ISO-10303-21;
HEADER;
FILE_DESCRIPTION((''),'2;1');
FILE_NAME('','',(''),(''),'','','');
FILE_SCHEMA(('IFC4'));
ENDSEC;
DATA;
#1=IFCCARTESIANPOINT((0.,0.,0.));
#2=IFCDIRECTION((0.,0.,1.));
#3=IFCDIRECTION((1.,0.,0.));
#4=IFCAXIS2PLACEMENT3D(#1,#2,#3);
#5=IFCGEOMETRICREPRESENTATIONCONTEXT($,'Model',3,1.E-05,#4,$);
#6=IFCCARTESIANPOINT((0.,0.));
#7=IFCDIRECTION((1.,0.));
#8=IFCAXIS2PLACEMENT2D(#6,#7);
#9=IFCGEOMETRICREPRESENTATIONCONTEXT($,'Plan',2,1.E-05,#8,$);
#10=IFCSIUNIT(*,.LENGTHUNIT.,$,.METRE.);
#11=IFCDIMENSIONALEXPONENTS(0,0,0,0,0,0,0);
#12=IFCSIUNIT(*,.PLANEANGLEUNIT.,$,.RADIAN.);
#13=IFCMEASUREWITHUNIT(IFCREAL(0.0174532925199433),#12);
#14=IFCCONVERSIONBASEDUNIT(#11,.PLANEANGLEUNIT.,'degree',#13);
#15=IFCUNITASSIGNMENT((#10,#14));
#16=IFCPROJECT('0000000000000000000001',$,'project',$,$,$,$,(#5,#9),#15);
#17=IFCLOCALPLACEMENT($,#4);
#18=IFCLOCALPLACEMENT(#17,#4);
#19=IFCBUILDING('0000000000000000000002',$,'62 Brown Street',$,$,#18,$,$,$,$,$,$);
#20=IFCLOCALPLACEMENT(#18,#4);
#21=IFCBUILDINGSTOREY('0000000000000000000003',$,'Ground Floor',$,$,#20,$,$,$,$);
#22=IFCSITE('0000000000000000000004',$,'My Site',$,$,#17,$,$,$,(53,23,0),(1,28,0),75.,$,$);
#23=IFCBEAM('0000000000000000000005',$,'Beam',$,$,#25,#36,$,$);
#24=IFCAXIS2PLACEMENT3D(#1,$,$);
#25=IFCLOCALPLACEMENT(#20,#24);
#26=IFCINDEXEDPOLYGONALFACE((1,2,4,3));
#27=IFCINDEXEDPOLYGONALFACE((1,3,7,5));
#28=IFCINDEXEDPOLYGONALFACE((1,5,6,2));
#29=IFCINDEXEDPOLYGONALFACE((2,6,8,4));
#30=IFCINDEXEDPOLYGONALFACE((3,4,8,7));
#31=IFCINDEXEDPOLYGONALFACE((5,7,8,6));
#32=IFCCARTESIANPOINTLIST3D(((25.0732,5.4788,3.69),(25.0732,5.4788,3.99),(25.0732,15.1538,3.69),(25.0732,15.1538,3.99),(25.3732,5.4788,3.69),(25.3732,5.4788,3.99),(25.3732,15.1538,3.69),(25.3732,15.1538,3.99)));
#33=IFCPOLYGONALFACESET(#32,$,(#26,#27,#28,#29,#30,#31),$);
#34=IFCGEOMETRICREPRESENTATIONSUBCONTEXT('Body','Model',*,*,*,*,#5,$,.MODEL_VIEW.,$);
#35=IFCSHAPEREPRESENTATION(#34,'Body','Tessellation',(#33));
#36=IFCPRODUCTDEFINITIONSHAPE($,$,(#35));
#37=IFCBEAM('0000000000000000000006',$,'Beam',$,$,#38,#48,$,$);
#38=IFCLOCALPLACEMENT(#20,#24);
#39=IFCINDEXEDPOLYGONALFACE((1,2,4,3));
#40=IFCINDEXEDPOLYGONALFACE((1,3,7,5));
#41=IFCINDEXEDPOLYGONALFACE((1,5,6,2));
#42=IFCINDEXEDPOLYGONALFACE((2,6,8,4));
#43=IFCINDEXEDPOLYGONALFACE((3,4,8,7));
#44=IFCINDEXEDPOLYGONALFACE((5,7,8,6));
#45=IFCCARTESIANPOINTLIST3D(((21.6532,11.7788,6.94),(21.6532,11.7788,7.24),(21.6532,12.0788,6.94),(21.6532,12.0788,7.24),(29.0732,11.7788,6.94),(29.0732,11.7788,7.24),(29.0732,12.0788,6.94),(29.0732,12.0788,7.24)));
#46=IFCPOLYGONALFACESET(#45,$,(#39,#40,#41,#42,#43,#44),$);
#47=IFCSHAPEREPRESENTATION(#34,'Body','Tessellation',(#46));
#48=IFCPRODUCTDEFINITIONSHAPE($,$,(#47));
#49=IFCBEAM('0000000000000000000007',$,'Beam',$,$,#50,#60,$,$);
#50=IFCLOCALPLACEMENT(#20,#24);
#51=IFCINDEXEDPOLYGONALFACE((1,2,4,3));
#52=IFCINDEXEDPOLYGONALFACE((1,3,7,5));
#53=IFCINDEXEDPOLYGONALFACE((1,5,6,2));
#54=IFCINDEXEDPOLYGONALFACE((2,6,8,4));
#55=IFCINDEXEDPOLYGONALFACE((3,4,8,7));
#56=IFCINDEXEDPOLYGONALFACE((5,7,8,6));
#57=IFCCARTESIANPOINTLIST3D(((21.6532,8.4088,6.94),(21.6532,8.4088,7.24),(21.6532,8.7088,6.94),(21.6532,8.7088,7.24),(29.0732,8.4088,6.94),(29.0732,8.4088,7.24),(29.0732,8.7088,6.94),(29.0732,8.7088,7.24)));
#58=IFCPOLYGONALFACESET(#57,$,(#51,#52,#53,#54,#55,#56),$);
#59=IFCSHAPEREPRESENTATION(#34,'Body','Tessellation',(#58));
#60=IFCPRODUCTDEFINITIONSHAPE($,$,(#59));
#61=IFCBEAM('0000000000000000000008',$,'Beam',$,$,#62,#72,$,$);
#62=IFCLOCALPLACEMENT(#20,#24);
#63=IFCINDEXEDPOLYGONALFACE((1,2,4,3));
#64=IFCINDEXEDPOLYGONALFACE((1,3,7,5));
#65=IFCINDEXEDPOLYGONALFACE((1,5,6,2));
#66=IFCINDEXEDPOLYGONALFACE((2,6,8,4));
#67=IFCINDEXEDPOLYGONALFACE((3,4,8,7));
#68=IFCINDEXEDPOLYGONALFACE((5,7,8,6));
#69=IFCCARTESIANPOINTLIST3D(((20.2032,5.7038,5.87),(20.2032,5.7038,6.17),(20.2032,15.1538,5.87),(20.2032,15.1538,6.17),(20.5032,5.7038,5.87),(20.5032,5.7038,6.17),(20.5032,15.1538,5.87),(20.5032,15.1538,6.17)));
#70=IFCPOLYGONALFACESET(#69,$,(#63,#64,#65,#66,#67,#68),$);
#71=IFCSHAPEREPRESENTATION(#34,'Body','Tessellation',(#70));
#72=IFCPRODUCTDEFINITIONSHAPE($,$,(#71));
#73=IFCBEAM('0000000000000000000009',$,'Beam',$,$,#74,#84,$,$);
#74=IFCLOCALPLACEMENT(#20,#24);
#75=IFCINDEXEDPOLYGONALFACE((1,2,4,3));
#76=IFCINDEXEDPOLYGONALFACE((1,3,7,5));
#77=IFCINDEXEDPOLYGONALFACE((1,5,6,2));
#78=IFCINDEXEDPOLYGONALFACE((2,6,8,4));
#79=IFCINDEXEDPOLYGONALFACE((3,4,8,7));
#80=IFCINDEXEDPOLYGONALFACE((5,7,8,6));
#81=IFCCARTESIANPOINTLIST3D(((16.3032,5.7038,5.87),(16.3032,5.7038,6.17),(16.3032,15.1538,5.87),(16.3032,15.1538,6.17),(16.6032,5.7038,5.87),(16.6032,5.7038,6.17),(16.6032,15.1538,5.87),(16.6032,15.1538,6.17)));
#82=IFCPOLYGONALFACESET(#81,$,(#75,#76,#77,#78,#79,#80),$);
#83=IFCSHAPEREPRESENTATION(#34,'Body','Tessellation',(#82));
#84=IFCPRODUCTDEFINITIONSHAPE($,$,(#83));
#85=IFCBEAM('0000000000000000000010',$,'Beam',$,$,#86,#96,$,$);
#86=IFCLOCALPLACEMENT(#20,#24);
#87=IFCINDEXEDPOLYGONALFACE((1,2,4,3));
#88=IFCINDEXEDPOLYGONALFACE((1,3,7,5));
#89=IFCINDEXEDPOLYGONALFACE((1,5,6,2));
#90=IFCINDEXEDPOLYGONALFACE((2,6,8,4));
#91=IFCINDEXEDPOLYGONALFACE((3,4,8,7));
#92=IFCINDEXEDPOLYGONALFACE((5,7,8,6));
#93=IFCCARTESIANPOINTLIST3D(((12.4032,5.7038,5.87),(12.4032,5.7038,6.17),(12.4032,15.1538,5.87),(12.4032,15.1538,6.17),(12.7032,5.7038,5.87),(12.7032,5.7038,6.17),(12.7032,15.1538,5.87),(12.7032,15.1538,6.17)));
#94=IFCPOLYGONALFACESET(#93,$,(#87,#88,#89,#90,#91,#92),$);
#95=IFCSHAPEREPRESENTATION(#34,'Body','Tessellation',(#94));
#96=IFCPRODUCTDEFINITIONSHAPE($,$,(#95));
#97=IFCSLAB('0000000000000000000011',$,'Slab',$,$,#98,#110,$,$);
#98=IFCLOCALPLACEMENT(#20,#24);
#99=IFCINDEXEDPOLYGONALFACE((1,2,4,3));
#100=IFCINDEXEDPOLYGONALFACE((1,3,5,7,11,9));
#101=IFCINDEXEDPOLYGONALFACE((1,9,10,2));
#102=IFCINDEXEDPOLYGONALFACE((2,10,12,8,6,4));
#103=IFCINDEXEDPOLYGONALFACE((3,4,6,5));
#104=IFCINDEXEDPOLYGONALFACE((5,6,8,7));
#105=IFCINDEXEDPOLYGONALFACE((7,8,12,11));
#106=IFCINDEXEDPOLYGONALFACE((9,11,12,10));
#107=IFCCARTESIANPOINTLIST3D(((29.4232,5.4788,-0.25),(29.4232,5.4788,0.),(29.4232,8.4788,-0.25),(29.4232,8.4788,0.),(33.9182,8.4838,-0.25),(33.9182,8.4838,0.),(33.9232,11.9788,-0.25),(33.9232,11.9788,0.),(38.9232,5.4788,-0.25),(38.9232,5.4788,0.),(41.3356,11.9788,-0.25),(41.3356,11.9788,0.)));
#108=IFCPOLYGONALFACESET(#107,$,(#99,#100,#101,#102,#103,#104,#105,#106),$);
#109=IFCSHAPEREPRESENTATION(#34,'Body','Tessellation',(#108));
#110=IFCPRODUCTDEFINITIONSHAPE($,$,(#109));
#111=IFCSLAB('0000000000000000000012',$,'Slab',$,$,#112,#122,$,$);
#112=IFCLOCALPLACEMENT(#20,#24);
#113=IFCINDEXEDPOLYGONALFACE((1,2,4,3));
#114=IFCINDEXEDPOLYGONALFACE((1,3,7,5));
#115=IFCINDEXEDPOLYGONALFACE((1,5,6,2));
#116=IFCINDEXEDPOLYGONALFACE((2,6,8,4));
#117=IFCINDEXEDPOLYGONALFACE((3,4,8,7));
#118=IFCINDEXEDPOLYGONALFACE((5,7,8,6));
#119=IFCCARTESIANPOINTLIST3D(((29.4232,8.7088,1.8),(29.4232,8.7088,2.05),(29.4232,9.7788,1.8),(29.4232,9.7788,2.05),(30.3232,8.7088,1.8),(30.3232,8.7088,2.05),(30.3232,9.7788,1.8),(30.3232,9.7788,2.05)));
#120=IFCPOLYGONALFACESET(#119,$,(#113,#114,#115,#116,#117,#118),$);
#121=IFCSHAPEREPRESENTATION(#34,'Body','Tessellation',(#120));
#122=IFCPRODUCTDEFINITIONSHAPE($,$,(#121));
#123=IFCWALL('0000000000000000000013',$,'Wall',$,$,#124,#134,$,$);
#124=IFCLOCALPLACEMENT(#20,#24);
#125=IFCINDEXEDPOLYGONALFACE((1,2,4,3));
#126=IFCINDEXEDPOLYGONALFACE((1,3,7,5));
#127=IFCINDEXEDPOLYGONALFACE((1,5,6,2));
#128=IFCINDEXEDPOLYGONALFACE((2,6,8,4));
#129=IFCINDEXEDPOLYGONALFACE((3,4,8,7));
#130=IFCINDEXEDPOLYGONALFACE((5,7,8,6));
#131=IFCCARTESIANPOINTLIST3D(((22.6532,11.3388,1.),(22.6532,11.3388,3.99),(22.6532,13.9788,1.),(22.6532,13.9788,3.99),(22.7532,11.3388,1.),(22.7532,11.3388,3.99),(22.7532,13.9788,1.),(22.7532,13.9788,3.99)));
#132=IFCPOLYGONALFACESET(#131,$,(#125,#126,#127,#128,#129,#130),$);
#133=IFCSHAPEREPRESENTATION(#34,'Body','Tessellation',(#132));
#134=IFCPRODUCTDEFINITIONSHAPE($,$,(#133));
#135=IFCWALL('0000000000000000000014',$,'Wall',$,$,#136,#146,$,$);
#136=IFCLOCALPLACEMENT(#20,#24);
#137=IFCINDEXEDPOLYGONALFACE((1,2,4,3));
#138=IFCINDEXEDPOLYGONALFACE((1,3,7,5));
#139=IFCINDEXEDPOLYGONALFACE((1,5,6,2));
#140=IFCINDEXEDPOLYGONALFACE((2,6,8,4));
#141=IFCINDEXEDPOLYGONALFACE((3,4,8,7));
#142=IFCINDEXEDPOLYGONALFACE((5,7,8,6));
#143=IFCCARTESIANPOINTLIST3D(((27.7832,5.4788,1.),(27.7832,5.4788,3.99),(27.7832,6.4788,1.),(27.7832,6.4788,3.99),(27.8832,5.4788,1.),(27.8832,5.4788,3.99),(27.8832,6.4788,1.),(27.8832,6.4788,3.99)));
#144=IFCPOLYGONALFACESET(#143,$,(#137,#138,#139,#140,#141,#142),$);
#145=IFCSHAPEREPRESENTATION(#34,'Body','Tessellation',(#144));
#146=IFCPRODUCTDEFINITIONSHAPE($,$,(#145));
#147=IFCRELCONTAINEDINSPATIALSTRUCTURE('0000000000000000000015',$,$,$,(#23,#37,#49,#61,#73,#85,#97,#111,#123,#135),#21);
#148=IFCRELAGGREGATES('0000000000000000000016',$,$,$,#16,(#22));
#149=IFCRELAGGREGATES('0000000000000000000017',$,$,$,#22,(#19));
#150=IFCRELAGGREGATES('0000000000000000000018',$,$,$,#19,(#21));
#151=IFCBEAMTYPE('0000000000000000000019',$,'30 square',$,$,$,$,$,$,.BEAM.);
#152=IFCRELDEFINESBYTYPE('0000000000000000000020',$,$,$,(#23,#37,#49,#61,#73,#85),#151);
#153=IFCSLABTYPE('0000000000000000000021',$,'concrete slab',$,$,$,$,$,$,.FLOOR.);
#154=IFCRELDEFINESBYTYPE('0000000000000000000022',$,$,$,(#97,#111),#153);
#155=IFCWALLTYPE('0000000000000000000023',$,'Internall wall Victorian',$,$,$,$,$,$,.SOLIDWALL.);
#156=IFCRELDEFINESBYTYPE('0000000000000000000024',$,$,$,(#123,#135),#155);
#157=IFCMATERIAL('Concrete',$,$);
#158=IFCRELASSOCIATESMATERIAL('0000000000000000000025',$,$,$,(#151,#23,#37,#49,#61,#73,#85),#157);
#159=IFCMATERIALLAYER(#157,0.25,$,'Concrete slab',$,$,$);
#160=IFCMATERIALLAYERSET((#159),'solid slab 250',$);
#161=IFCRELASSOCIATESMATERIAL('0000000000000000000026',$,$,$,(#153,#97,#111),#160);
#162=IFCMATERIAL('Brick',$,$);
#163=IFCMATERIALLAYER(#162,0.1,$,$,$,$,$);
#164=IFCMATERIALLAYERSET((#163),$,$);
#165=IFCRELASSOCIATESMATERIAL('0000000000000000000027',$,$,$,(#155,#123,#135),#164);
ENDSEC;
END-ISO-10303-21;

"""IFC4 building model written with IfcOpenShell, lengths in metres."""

from ifc_helpers import new_model, entity, si_unit, converted_unit, frame, origin_with_axes, origin_2d_with_axis, place, context, subcontext, project, spatial, line, indexed_curve, rectangle, outline, extrude, material, layer, layer_set, layer_usage, material_profile, profile_set, profile_usage, type_object, element, save


model = new_model("IFC4")

# Units and contexts
model_context = context("Model", 3, precision=1e-05, world=origin_with_axes())
plan_context = context("Plan", 2, precision=1e-05, world=origin_2d_with_axis())
body_context_1 = subcontext(model_context, "Body", "Model", "MODEL_VIEW")
ifc_project = project(units=[si_unit("LENGTHUNIT", "METRE"), converted_unit("PLANEANGLEUNIT", "degree", entity("IfcReal", 0.0174532925199433), si_unit("PLANEANGLEUNIT", "RADIAN"), dimensions=[0, 0, 0, 0, 0, 0, 0])], contexts=[model_context, plan_context])

# Site, building, storey
site_placement = place(None, origin_with_axes())
site = spatial("IfcSite", under=ifc_project, at=site_placement, Name="My Site", RefLatitude=(53, 23, 0), RefLongitude=(1, 28, 0), RefElevation=75.0)
building_placement = place(site_placement, origin_with_axes())
building = spatial("IfcBuilding", under=site, at=building_placement, Name="62 Brown Street")
storey_placement = place(building_placement, origin_with_axes())
storey = spatial("IfcBuildingStorey", under=building, at=storey_placement, Name="Ground Floor")

# Shared definitions
ifc_material_1 = material(Name="Concrete")

# Beams
ifc_material_profile_1 = material_profile(ifc_material_1, rectangle(XDim=0.3, YDim=0.3))
ifc_profile_set_1 = profile_set([ifc_material_profile_1])
ifc_profile_usage_1 = profile_usage(ifc_profile_set_1, cardinal=5)
beam_type = type_object("IfcBeamType", Name="30 square", PredefinedType="BEAM", material=ifc_profile_set_1)
beam_1_placement = place(storey_placement, frame((25.2232, 5.4788, 3.84), z_axis=(0.0, 1.0, 0.0), x_axis=(-1.0, 0.0, 0.0)))
element("IfcBeam", 1, at=beam_1_placement, inside=storey, type_object=beam_type, material=ifc_profile_usage_1, Name="Beam", context=body_context_1, shape_type="SweptSolid", body=[
    extrude(rectangle(XDim=0.3, YDim=0.3), origin_with_axes(), (0.0, 0.0, 1.0), 9.675),
])
ifc_profile_usage_2 = profile_usage(ifc_profile_set_1, cardinal=5)
beam_2_placement = place(storey_placement, frame((29.0732, 11.9288, 7.09), z_axis=(-1.0, 0.0, 0.0), x_axis=(0.0, -1.0, 0.0)))
element("IfcBeam", 2, at=beam_2_placement, inside=storey, type_object=beam_type, material=ifc_profile_usage_2, Name="Beam", context=body_context_1, shape_type="SweptSolid", body=[
    extrude(rectangle(XDim=0.3, YDim=0.3), origin_with_axes(), (0.0, 0.0, 1.0), 7.42),
])
ifc_profile_usage_3 = profile_usage(ifc_profile_set_1, cardinal=5)
beam_3_placement = place(storey_placement, frame((29.0732, 8.5588, 7.09), z_axis=(-1.0, 0.0, 0.0), x_axis=(0.0, -1.0, 0.0)))
element("IfcBeam", 3, at=beam_3_placement, inside=storey, type_object=beam_type, material=ifc_profile_usage_3, Name="Beam", context=body_context_1, shape_type="SweptSolid", body=[
    extrude(rectangle(XDim=0.3, YDim=0.3), origin_with_axes(), (0.0, 0.0, 1.0), 7.42),
])
ifc_profile_usage_4 = profile_usage(ifc_profile_set_1, cardinal=5)
beam_4_placement = place(storey_placement, frame((20.3532, 15.1538, 6.02), z_axis=(0.0, -1.0, 0.0), x_axis=(1.0, 0.0, 0.0)))
element("IfcBeam", 4, at=beam_4_placement, inside=storey, type_object=beam_type, material=ifc_profile_usage_4, Name="Beam", context=body_context_1, shape_type="SweptSolid", body=[
    extrude(rectangle(XDim=0.3, YDim=0.3), origin_with_axes(), (0.0, 0.0, 1.0), 9.45),
])
ifc_profile_usage_5 = profile_usage(ifc_profile_set_1, cardinal=5)
beam_5_placement = place(storey_placement, frame((16.4532, 15.1538, 6.02), z_axis=(0.0, -1.0, 0.0), x_axis=(1.0, 0.0, 0.0)))
element("IfcBeam", 5, at=beam_5_placement, inside=storey, type_object=beam_type, material=ifc_profile_usage_5, Name="Beam", context=body_context_1, shape_type="SweptSolid", body=[
    extrude(rectangle(XDim=0.3, YDim=0.3), origin_with_axes(), (0.0, 0.0, 1.0), 9.45),
])
ifc_profile_usage_6 = profile_usage(ifc_profile_set_1, cardinal=5)
beam_6_placement = place(storey_placement, frame((12.5532, 15.1538, 6.02), z_axis=(0.0, -1.0, 0.0), x_axis=(1.0, 0.0, 0.0)))
element("IfcBeam", 6, at=beam_6_placement, inside=storey, type_object=beam_type, material=ifc_profile_usage_6, Name="Beam", context=body_context_1, shape_type="SweptSolid", body=[
    extrude(rectangle(XDim=0.3, YDim=0.3), origin_with_axes(), (0.0, 0.0, 1.0), 9.45),
])

# Slabs
ifc_layer_1 = layer(ifc_material_1, 0.25, Name="Concrete slab")
ifc_layer_set_1 = layer_set([ifc_layer_1], Name="solid slab 250")
ifc_layer_usage_1 = layer_usage(ifc_layer_set_1, "AXIS3", "POSITIVE", 0.0)
slab_type = type_object("IfcSlabType", Name="concrete slab", PredefinedType="FLOOR", material=ifc_layer_set_1)
slab_1_placement = place(storey_placement, frame((29.4232, 5.4788, -0.25), z_axis=(0.0, 0.0, 1.0), x_axis=(1.0, 0.0, 0.0)))
element("IfcSlab", 7, at=slab_1_placement, inside=storey, type_object=slab_type, material=ifc_layer_usage_1, Name="Slab", context=body_context_1, shape_type="SweptSolid", body=[
    extrude(outline(indexed_curve([(0.0, 0.0), (9.5, 0.0), (11.9124, 6.5), (0.0, 3.0), (4.5, 6.5), (4.495, 3.005)], segments=[line(1, 2), line(2, 3), line(3, 5), line(5, 6), line(6, 4), line(4, 1)], self_intersect=False)), None, (0.0, 0.0, 1.0), 0.25),
])
ifc_layer_usage_2 = layer_usage(ifc_layer_set_1, "AXIS3", "POSITIVE", 0.0)
slab_2_placement = place(storey_placement, frame((29.4232, 8.7088, 1.8), z_axis=(0.0, 0.0, 1.0), x_axis=(1.0, 0.0, 0.0)))
element("IfcSlab", 8, at=slab_2_placement, inside=storey, type_object=slab_type, material=ifc_layer_usage_2, Name="Slab", context=body_context_1, shape_type="SweptSolid", body=[
    extrude(outline(indexed_curve([(0.9, 1.07), (0.9, 0.0), (0.0, 0.0), (0.0, 1.07)], segments=[line(3, 2), line(2, 1), line(1, 4), line(4, 3)], self_intersect=False)), None, (0.0, 0.0, 1.0), 0.25),
])

# Walls
ifc_material_2 = material(Name="Brick")
ifc_layer_2 = layer(ifc_material_2, 0.1)
ifc_layer_set_2 = layer_set([ifc_layer_2])
ifc_layer_usage_3 = layer_usage(ifc_layer_set_2, "AXIS2", "POSITIVE", 0.0)
wall_type_1 = type_object("IfcWallType", Name="Internall wall Victorian", PredefinedType="SOLIDWALL", material=ifc_layer_set_2)
wall_1_placement = place(storey_placement, frame((22.7532, 11.3388, 1.0), z_axis=(0.0, 0.0, 1.0), x_axis=(0.0, 1.0, 0.0)))
element("IfcWall", 9, at=wall_1_placement, inside=storey, type_object=wall_type_1, material=ifc_layer_usage_3, Name="Wall", context=body_context_1, shape_type="SweptSolid", body=[
    extrude(outline(indexed_curve([(0.0, 0.0), (0.0, 0.1), (2.64, 0.1), (2.64, 0.0), (0.0, 0.0)], self_intersect=False)), origin_with_axes(), (0.0, 0.0, 1.0), 2.99),
])
ifc_layer_usage_4 = layer_usage(ifc_layer_set_2, "AXIS2", "POSITIVE", 0.0)
wall_2_placement = place(storey_placement, frame((27.8832, 5.4788, 1.0), z_axis=(0.0, 0.0, 1.0), x_axis=(0.0, 1.0, 0.0)))
element("IfcWall", 10, at=wall_2_placement, inside=storey, type_object=wall_type_1, material=ifc_layer_usage_4, Name="Wall", context=body_context_1, shape_type="SweptSolid", body=[
    extrude(outline(indexed_curve([(0.0, 0.0), (0.0, 0.1), (1.0, 0.1), (1.0, 0.0), (0.0, 0.0)], self_intersect=False)), origin_with_axes(), (0.0, 0.0, 1.0), 2.99),
])

save(model, "model.ifc")
